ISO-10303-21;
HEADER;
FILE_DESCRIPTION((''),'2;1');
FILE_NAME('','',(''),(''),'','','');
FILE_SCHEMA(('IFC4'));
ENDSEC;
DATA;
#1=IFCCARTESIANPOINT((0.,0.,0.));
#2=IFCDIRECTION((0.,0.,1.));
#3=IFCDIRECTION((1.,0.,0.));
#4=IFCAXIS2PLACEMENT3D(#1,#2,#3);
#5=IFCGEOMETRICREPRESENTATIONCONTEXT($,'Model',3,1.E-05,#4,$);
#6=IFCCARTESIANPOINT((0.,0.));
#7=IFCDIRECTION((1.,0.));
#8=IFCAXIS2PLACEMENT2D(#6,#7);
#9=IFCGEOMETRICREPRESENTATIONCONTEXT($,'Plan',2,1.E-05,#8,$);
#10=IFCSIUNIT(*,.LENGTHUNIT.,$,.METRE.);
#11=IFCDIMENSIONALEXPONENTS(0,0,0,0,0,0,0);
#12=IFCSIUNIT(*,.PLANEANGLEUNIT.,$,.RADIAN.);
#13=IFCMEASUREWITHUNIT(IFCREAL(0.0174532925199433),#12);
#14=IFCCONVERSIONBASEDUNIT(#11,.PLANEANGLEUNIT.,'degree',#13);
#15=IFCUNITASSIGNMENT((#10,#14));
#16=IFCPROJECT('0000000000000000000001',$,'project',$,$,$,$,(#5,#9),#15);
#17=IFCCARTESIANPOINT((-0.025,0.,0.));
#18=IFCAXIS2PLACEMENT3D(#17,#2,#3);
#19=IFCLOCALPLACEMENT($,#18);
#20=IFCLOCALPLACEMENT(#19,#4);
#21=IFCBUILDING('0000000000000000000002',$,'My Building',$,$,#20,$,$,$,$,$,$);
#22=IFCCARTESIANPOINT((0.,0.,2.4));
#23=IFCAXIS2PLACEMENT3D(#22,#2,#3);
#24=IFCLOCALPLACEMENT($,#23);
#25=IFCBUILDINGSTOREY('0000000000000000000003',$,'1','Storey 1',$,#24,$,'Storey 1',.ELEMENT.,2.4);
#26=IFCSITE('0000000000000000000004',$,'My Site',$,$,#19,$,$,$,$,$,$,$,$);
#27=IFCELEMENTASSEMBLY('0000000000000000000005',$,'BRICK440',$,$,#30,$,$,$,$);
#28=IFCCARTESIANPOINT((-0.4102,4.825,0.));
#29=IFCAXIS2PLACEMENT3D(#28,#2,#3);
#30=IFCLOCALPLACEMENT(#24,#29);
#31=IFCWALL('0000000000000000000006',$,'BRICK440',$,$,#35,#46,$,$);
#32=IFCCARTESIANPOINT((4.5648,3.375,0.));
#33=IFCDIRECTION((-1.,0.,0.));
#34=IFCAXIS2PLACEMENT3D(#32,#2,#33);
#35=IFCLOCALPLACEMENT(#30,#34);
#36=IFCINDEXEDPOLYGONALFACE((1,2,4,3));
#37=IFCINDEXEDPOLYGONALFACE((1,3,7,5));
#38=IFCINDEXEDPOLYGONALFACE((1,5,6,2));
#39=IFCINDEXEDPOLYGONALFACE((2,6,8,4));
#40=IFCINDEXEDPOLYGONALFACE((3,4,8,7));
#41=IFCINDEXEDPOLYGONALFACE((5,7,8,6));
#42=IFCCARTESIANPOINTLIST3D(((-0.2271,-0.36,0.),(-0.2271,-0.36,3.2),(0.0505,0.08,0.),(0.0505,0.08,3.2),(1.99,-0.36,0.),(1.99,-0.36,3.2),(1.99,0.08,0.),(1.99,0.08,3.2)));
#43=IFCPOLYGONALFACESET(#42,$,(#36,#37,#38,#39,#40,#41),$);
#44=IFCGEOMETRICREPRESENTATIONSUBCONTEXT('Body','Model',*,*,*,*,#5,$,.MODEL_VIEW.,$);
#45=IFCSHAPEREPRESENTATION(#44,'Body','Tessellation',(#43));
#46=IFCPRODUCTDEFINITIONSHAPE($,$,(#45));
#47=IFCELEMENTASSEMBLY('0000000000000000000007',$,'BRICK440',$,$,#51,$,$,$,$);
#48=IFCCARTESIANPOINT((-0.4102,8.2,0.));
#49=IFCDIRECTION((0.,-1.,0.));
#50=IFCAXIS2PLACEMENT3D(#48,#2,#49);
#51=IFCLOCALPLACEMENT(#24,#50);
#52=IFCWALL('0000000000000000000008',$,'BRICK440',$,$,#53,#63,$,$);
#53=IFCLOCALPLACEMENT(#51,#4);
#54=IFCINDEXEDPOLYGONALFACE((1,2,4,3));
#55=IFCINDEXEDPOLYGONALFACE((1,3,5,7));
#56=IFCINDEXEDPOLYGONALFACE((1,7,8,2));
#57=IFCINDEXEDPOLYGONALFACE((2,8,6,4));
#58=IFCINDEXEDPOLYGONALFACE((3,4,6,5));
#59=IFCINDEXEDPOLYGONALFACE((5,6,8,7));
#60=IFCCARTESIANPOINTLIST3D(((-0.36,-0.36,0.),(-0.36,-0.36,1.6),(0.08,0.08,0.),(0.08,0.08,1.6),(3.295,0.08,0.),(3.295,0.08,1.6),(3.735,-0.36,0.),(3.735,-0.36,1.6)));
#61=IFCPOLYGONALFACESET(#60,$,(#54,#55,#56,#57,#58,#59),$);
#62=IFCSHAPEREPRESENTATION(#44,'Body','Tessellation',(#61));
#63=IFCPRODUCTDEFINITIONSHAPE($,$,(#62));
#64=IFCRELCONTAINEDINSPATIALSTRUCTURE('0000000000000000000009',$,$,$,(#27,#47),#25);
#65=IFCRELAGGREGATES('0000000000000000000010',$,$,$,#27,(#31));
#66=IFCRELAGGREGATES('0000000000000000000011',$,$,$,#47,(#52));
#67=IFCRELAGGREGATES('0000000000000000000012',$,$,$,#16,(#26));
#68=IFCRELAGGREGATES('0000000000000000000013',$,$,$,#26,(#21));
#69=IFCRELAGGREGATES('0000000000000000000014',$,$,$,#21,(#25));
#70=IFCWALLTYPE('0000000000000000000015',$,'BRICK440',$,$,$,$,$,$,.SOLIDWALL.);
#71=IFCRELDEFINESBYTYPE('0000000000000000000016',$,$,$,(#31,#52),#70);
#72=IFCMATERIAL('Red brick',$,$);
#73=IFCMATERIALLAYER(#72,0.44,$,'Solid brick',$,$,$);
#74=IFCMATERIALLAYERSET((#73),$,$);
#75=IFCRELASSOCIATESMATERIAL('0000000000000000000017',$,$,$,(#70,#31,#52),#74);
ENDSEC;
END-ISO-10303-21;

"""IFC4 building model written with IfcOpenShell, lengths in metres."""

from ifc_helpers import new_model, entity, si_unit, converted_unit, frame, origin, origin_with_axes, origin_2d_with_axis, place, context, subcontext, project, spatial, polyline, outline, extrude, material, layer, layer_set, layer_usage, type_object, element, aggregate, save


model = new_model("IFC4")

# Units and contexts
model_context = context("Model", 3, precision=1e-05, world=origin_with_axes())
plan_context = context("Plan", 2, precision=1e-05, world=origin_2d_with_axis())
body_context = subcontext(model_context, "Body", "Model", "MODEL_VIEW")
ifc_project = project(units=[si_unit("LENGTHUNIT", "METRE"), converted_unit("PLANEANGLEUNIT", "degree", entity("IfcReal", 0.0174532925199433), si_unit("PLANEANGLEUNIT", "RADIAN"), dimensions=[0, 0, 0, 0, 0, 0, 0])], contexts=[model_context, plan_context])

# Site, building, storey
site_placement = place(None, frame((-0.025, 0.0, 0.0), z_axis=(0.0, 0.0, 1.0), x_axis=(1.0, 0.0, 0.0)))
site = spatial("IfcSite", under=ifc_project, at=site_placement, Name="My Site")
building_placement = place(site_placement, origin_with_axes())
building = spatial("IfcBuilding", under=site, at=building_placement, Name="My Building")
storey_placement = place(None, frame((0.0, 0.0, 2.4), z_axis=(0.0, 0.0, 1.0), x_axis=(1.0, 0.0, 0.0)))
storey = spatial("IfcBuildingStorey", under=building, at=storey_placement, Name="1", Description="Storey 1", LongName="Storey 1", CompositionType="ELEMENT", Elevation=2.4)

# Element assemblies, walls
assembly_1_placement = place(storey_placement, frame((-0.4102, 4.825, 0.0), z_axis=(0.0, 0.0, 1.0), x_axis=(1.0, 0.0, 0.0)))
assembly_1 = element("IfcElementAssembly", 1, at=assembly_1_placement, inside=storey, Name="BRICK440")
ifc_material_1 = material(Name="Red brick")
ifc_layer_1 = layer(ifc_material_1, 0.44, Name="Solid brick")
ifc_layer_set_1 = layer_set([ifc_layer_1])
ifc_layer_usage_1 = layer_usage(ifc_layer_set_1, "AXIS2", "POSITIVE", -0.36)
wall_type_1 = type_object("IfcWallType", Name="BRICK440", PredefinedType="SOLIDWALL", material=ifc_layer_set_1)
wall_1_placement = place(assembly_1_placement, frame((4.5648, 3.375, 0.0), z_axis=(0.0, 0.0, 1.0), x_axis=(-1.0, 0.0, 0.0)))
wall_1 = element("IfcWall", 2, at=wall_1_placement, type_object=wall_type_1, material=ifc_layer_usage_1, Name="BRICK440", context=body_context, shape_type="SweptSolid", body=[
    extrude(outline(polyline([(0.0505, 0.08), (-0.2271, -0.36), (1.99, -0.36), (1.99, 0.08), (0.0505, 0.08)])), origin(), (0.0, 0.0, 1.0), 3.2),
])
aggregate(assembly_1, [wall_1])
assembly_2_placement = place(storey_placement, frame((-0.4102, 8.2, 0.0), z_axis=(0.0, 0.0, 1.0), x_axis=(0.0, -1.0, 0.0)))
assembly_2 = element("IfcElementAssembly", 3, at=assembly_2_placement, inside=storey, Name="BRICK440")
ifc_layer_usage_2 = layer_usage(ifc_layer_set_1, "AXIS2", "POSITIVE", -0.36)
wall_2_placement = place(assembly_2_placement, origin_with_axes())
wall_2 = element("IfcWall", 4, at=wall_2_placement, type_object=wall_type_1, material=ifc_layer_usage_2, Name="BRICK440", context=body_context, shape_type="SweptSolid", body=[
    extrude(outline(polyline([(0.08, 0.08), (-0.36, -0.36), (3.735, -0.36), (3.295, 0.08), (0.08, 0.08)])), origin(), (0.0, 0.0, 1.0), 1.6),
])
aggregate(assembly_2, [wall_2])

save(model, "model.ifc")
